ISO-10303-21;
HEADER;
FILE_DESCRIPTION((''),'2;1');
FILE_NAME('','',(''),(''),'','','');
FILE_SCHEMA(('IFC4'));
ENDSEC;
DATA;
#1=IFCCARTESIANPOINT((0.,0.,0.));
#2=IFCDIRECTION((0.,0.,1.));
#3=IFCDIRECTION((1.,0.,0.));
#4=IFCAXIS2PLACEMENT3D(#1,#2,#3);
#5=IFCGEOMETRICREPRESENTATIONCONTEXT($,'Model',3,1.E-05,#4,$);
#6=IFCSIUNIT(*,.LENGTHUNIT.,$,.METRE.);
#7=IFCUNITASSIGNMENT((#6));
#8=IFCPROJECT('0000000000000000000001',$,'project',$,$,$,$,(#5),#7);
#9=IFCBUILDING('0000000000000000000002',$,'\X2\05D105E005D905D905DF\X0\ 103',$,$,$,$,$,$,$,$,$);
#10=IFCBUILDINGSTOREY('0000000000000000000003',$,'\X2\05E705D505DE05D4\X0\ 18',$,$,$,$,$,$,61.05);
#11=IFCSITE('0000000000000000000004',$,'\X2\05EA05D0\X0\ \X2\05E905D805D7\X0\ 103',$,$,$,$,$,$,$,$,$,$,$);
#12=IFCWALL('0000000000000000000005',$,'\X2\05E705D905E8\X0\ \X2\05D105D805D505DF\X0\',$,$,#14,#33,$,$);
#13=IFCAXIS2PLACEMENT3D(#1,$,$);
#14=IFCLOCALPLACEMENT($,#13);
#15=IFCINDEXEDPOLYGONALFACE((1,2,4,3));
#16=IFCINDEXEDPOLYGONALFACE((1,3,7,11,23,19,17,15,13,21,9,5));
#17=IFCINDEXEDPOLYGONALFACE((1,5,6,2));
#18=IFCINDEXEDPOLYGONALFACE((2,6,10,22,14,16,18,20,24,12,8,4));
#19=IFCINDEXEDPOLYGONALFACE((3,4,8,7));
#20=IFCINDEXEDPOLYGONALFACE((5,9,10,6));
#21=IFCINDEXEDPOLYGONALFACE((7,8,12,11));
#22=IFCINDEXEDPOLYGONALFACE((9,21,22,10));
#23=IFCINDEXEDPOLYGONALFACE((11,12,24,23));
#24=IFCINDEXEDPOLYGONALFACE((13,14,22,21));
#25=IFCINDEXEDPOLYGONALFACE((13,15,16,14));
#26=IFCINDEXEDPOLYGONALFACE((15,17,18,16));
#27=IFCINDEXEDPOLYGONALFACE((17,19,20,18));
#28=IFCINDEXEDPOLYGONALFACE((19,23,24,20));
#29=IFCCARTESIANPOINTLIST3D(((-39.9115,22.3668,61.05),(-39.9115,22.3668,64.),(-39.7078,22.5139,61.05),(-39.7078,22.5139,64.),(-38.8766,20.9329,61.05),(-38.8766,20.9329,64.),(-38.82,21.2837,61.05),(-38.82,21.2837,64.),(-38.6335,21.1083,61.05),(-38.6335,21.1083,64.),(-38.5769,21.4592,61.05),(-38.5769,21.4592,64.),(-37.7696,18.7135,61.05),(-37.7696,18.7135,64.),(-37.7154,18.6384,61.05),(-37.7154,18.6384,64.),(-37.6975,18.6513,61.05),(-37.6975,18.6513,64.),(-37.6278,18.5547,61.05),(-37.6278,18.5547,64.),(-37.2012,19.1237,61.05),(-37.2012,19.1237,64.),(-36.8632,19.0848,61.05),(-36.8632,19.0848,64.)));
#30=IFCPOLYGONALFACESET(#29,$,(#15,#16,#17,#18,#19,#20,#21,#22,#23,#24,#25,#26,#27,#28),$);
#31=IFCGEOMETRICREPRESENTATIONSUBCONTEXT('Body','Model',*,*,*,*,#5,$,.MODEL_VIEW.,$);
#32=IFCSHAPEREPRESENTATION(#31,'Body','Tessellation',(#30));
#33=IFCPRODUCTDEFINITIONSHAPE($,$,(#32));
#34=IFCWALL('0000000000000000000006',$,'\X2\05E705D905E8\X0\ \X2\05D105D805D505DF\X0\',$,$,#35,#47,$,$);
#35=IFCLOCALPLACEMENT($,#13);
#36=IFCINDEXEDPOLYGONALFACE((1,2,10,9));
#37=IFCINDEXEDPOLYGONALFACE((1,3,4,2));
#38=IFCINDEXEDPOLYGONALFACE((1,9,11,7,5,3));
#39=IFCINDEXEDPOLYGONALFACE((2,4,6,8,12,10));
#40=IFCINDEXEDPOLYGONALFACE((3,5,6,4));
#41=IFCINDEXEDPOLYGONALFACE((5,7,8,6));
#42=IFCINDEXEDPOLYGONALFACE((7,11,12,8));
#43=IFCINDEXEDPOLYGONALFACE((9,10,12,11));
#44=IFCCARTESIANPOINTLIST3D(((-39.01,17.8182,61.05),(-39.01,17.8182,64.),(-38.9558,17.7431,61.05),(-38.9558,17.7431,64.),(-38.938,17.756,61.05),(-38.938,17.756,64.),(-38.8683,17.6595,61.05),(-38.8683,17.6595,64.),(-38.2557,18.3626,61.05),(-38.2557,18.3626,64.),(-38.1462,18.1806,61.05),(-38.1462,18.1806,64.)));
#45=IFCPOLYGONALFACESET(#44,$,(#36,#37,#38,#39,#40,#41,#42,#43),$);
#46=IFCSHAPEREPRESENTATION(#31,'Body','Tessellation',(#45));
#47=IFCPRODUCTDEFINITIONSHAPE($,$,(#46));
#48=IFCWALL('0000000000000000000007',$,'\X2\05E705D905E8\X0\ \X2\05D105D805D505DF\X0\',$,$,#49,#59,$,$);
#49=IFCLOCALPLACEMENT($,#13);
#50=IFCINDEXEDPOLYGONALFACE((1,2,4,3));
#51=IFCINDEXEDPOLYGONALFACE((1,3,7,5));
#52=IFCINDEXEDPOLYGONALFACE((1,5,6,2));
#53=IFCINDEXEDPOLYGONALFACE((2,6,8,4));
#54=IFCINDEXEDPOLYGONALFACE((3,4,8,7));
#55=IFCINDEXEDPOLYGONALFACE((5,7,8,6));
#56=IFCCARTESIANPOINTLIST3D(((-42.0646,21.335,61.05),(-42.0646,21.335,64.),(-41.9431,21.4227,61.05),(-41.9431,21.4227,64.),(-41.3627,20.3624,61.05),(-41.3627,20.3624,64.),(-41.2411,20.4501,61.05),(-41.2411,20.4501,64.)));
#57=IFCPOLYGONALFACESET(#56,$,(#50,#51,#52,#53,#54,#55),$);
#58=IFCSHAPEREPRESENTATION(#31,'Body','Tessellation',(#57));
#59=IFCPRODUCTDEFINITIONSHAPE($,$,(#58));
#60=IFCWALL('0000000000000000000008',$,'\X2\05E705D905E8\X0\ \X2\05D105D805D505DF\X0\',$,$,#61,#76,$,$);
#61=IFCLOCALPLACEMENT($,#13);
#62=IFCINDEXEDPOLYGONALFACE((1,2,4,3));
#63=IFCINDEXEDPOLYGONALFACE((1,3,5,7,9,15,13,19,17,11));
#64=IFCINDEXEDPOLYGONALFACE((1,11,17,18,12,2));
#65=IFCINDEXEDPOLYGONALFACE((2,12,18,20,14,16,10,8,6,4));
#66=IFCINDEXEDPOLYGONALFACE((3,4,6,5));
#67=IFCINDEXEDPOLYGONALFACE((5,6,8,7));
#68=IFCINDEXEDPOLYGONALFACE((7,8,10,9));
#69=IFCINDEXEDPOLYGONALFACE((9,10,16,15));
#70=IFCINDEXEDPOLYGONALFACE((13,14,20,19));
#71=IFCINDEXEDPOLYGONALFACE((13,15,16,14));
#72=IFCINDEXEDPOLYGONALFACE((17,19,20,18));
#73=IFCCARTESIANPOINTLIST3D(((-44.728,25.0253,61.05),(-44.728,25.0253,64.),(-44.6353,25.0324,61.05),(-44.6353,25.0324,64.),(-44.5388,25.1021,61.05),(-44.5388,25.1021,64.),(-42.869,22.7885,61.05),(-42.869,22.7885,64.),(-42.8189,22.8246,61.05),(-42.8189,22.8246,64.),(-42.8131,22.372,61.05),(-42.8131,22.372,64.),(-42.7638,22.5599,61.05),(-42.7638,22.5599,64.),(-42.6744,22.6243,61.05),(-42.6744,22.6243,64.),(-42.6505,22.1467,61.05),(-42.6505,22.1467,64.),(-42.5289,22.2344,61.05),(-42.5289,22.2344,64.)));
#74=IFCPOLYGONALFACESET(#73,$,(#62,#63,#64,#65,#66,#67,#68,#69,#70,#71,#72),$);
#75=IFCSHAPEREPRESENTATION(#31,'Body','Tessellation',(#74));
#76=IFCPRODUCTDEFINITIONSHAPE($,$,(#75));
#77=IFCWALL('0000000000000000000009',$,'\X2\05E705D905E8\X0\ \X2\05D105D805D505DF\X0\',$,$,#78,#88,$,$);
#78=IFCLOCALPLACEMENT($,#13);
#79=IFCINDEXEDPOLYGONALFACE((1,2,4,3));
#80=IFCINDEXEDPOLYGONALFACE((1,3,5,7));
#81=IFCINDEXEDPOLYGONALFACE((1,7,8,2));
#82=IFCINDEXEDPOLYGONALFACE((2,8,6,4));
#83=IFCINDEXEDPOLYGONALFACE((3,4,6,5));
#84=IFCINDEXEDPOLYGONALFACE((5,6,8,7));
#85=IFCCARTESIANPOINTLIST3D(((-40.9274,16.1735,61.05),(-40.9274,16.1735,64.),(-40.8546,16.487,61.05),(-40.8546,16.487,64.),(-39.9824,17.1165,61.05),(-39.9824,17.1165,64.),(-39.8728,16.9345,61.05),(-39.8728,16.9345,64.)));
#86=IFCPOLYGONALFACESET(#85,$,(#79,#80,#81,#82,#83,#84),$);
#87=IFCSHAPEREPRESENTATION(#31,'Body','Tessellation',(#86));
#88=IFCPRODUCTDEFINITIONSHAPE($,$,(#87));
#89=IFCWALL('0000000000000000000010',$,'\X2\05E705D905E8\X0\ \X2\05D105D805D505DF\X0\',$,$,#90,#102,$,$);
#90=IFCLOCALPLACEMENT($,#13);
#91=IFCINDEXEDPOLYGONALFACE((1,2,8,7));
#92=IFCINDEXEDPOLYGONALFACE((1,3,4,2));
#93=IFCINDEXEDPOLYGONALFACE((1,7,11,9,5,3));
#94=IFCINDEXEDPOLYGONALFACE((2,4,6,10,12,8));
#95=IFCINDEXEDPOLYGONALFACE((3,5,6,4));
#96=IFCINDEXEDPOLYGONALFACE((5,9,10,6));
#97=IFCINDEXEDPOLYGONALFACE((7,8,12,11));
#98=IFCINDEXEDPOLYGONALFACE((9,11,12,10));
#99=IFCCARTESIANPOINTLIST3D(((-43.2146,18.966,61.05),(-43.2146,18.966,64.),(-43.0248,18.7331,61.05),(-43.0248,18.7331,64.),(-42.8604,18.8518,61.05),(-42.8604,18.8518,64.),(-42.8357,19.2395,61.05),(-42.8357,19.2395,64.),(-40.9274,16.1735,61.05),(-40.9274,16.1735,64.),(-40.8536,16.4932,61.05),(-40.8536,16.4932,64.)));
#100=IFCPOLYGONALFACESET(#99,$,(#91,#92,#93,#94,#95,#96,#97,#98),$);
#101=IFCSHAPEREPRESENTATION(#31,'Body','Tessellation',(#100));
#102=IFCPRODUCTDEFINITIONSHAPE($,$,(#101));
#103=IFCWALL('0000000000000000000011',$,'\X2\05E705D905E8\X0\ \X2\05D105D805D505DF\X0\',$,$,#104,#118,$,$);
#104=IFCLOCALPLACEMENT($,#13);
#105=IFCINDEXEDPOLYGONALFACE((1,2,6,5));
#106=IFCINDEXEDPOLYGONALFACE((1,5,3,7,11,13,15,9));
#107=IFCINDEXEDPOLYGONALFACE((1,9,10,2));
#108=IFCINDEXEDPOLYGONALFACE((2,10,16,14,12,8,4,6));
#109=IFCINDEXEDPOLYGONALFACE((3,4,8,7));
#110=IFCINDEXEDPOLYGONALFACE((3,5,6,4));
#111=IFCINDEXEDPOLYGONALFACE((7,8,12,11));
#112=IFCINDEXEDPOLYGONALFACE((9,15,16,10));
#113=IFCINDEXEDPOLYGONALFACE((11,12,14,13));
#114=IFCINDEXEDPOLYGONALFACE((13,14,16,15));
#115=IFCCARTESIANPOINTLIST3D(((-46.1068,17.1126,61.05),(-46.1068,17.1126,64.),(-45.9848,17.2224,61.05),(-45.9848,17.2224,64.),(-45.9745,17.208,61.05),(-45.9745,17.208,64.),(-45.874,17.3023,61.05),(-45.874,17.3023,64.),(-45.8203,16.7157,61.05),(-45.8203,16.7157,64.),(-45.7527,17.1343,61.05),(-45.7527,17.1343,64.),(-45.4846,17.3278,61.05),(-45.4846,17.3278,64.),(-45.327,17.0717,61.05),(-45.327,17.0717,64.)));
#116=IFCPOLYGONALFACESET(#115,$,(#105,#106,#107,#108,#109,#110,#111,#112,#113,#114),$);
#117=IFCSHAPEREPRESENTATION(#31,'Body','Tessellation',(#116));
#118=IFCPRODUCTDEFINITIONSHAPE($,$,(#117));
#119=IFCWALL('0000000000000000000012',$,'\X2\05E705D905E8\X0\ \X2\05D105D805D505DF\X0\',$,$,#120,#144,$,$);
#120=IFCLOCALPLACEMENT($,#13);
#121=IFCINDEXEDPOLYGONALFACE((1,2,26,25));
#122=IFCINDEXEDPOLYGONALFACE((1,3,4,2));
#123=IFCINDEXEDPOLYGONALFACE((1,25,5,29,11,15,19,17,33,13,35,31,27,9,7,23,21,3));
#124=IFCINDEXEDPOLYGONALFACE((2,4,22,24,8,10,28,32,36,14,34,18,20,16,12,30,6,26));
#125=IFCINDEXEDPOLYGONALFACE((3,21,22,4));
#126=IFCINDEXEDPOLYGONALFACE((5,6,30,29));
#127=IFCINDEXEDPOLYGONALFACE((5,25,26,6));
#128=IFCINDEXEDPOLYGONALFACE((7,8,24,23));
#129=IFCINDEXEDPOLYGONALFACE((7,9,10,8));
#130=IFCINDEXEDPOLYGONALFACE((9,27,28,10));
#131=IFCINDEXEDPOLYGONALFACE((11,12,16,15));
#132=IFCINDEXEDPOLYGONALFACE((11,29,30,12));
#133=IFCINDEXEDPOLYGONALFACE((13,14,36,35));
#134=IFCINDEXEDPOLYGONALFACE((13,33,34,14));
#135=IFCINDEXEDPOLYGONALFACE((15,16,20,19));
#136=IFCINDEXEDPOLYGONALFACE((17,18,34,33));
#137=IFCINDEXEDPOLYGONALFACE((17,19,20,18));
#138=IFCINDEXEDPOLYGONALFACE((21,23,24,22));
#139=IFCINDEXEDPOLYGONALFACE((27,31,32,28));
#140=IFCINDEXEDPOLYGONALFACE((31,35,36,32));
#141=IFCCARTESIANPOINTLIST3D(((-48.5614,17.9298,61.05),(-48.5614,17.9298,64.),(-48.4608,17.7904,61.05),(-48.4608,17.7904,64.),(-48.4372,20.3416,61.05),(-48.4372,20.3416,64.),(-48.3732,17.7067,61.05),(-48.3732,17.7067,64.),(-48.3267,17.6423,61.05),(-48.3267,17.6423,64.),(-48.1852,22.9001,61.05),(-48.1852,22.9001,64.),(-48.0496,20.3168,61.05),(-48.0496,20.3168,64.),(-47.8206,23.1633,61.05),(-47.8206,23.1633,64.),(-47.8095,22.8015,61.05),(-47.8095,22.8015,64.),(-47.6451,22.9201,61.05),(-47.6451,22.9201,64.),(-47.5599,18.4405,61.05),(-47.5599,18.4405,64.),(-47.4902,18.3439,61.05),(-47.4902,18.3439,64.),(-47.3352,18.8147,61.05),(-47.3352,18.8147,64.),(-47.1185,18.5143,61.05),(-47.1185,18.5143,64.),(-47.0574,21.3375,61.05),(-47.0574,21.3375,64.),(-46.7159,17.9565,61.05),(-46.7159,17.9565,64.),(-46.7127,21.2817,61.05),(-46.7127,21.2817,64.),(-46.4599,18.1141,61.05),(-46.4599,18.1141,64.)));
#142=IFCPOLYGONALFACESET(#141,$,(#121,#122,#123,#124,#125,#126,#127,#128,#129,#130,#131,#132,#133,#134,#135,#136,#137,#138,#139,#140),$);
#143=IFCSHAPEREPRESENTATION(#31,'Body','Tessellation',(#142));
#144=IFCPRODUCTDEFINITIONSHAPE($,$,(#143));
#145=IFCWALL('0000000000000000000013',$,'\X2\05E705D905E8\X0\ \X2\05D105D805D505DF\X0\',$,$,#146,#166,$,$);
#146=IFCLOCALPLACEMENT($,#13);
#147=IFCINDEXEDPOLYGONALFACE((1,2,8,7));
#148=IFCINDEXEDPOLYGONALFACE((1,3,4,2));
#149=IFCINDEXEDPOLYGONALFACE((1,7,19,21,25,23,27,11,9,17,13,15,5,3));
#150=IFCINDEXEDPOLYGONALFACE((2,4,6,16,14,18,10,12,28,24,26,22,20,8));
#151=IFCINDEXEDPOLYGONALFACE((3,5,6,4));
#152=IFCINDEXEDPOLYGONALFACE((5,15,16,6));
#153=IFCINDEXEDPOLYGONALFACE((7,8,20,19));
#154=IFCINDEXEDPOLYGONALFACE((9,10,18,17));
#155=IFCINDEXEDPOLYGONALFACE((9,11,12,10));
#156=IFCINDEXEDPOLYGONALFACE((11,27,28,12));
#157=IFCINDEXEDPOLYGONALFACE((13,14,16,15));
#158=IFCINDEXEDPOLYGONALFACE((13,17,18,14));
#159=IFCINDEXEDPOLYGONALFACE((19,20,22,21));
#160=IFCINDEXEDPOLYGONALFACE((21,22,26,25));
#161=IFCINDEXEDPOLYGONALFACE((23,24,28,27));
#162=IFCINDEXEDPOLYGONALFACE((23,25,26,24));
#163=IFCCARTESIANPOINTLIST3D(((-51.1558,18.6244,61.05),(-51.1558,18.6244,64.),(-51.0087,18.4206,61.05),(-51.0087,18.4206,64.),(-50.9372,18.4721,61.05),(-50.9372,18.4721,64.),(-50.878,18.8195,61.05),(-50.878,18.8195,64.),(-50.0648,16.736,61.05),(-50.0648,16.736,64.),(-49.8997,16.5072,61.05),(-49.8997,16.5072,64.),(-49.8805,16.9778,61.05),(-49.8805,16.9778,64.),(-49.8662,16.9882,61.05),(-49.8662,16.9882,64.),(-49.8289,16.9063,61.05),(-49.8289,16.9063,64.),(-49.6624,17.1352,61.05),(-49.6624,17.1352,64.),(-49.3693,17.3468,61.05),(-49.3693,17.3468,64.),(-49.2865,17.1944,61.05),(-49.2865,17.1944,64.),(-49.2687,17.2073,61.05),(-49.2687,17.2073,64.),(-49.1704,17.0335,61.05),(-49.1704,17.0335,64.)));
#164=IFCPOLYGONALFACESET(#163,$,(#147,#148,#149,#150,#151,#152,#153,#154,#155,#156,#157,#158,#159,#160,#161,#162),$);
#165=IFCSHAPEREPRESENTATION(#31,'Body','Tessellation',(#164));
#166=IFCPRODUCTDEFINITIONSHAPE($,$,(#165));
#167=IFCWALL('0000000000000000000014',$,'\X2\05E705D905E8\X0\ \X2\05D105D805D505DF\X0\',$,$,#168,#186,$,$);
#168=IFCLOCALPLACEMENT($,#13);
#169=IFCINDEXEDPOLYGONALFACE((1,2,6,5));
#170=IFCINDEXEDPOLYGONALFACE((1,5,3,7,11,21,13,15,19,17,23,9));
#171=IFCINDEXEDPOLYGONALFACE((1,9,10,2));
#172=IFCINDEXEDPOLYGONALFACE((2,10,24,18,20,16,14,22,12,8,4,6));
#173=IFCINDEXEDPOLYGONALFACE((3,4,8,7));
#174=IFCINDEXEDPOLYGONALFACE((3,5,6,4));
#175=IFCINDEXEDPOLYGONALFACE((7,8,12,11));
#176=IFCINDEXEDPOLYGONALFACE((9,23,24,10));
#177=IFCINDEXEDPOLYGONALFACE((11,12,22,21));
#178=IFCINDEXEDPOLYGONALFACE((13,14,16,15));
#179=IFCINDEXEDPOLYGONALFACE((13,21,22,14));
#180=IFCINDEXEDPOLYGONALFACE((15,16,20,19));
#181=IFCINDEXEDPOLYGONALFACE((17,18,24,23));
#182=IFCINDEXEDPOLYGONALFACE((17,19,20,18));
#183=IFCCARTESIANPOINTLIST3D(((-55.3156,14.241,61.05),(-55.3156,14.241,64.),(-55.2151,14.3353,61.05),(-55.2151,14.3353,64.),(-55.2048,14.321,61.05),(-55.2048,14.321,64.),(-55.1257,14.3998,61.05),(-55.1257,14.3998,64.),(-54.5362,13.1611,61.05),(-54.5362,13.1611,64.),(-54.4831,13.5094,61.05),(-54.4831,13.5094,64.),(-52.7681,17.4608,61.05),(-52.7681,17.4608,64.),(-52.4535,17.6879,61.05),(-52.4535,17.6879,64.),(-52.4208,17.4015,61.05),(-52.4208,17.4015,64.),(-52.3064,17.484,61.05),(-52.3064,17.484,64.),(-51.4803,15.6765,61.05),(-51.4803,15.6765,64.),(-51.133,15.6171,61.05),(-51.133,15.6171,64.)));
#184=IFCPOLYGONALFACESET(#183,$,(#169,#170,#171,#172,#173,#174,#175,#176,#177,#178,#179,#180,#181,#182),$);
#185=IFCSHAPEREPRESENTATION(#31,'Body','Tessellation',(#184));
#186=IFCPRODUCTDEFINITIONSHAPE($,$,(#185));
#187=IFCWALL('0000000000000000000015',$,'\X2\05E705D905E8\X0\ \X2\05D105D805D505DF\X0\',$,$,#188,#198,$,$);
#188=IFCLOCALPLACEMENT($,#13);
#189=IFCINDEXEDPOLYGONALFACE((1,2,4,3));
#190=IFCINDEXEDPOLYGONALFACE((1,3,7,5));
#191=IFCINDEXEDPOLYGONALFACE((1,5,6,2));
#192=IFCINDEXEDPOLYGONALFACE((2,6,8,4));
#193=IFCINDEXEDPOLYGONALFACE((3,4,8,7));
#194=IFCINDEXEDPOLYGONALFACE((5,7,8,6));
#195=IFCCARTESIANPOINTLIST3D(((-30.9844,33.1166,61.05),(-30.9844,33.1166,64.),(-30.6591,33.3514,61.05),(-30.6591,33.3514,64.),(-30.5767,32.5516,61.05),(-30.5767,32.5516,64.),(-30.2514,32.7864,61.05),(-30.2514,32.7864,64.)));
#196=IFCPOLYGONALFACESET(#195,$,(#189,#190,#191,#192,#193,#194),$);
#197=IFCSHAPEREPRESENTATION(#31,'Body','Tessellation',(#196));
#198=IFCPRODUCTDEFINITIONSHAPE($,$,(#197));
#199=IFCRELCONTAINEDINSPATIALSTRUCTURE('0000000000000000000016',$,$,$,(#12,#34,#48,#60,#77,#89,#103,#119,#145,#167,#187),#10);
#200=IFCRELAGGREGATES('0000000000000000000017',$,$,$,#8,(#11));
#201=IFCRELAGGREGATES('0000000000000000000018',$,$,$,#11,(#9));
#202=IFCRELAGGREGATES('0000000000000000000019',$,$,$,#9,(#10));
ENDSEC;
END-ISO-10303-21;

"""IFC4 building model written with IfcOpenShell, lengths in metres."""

from ifc_helpers import new_model, si_unit, frame, origin_with_axes, context, subcontext, project, spatial, polyline, outline, extrude, element, save


model = new_model("IFC4")

# Units and contexts
model_context = context("Model", 3, precision=1e-05, world=origin_with_axes())
body_context = subcontext(model_context, "Body", "Model", "MODEL_VIEW")
ifc_project = project(units=[si_unit("LENGTHUNIT", "METRE")], contexts=[model_context])

# Site, building, storey
site = spatial("IfcSite", under=ifc_project, Name="תא שטח 103")
building = spatial("IfcBuilding", under=site, Name="בניין 103")
storey = spatial("IfcBuildingStorey", under=building, Name="קומה 18", Elevation=61.05)

# Walls
element("IfcWall", 1, inside=storey, Name="קיר בטון", context=body_context, shape_type="SweptSolid", body=[
    extrude(outline(polyline([(-37.6975, 18.6513), (-37.7154, 18.6384), (-37.7696, 18.7135), (-37.2012, 19.1237), (-38.6335, 21.1083), (-38.8766, 20.9329), (-39.9115, 22.3668), (-39.7078, 22.5139), (-38.82, 21.2837), (-38.5769, 21.4592), (-36.8632, 19.0848), (-37.6278, 18.5547), (-37.6975, 18.6513)])), frame((0.0, 0.0, 61.05)), (0.0, 0.0, 1.0), 2.95),
])
element("IfcWall", 2, inside=storey, Name="קיר בטון", context=body_context, shape_type="SweptSolid", body=[
    extrude(outline(polyline([(-38.938, 17.756), (-38.9558, 17.7431), (-39.01, 17.8182), (-38.2557, 18.3626), (-38.1462, 18.1806), (-38.8683, 17.6595), (-38.938, 17.756)])), frame((0.0, 0.0, 61.05)), (0.0, 0.0, 1.0), 2.95),
])
element("IfcWall", 3, inside=storey, Name="קיר בטון", context=body_context, shape_type="SweptSolid", body=[
    extrude(outline(polyline([(-41.2411, 20.4501), (-41.3627, 20.3624), (-42.0646, 21.335), (-41.9431, 21.4227), (-41.2411, 20.4501)])), frame((0.0, 0.0, 61.05)), (0.0, 0.0, 1.0), 2.95),
])
element("IfcWall", 4, inside=storey, Name="קיר בטון", context=body_context, shape_type="SweptSolid", body=[
    extrude(outline(polyline([(-42.6505, 22.1467), (-42.8131, 22.372), (-44.728, 25.0253), (-44.6353, 25.0324), (-44.5388, 25.1021), (-42.869, 22.7885), (-42.8189, 22.8246), (-42.6744, 22.6243), (-42.7638, 22.5599), (-42.5289, 22.2344), (-42.6505, 22.1467)])), frame((0.0, 0.0, 61.05)), (0.0, 0.0, 1.0), 2.95),
])
element("IfcWall", 5, inside=storey, Name="קיר בטון", context=body_context, shape_type="SweptSolid", body=[
    extrude(outline(polyline([(-40.9274, 16.1735), (-40.8546, 16.487), (-39.9824, 17.1165), (-39.8728, 16.9345), (-40.9274, 16.1735)])), frame((0.0, 0.0, 61.05)), (0.0, 0.0, 1.0), 2.95),
])
element("IfcWall", 6, inside=storey, Name="קיר בטון", context=body_context, shape_type="SweptSolid", body=[
    extrude(outline(polyline([(-43.0248, 18.7331), (-43.2146, 18.966), (-42.8357, 19.2395), (-40.8536, 16.4932), (-40.9274, 16.1735), (-42.8604, 18.8518), (-43.0248, 18.7331)])), frame((0.0, 0.0, 61.05)), (0.0, 0.0, 1.0), 2.95),
])
element("IfcWall", 7, inside=storey, Name="קיר בטון", context=body_context, shape_type="SweptSolid", body=[
    extrude(outline(polyline([(-45.9745, 17.208), (-45.9848, 17.2224), (-45.874, 17.3023), (-45.7527, 17.1343), (-45.4846, 17.3278), (-45.327, 17.0717), (-45.8203, 16.7157), (-46.1068, 17.1126), (-45.9745, 17.208)])), frame((0.0, 0.0, 61.05)), (0.0, 0.0, 1.0), 2.95),
])
element("IfcWall", 8, inside=storey, Name="קיר בטון", context=body_context, shape_type="SweptSolid", body=[
    extrude(outline(polyline([(-48.4608, 17.7904), (-48.5614, 17.9298), (-47.3352, 18.8147), (-48.4372, 20.3416), (-47.0574, 21.3375), (-48.1852, 22.9001), (-47.8206, 23.1633), (-47.6451, 22.9201), (-47.8095, 22.8015), (-46.7127, 21.2817), (-48.0496, 20.3168), (-46.4599, 18.1141), (-46.7159, 17.9565), (-47.1185, 18.5143), (-48.3267, 17.6423), (-48.3732, 17.7067), (-47.4902, 18.3439), (-47.5599, 18.4405), (-48.4608, 17.7904)])), frame((0.0, 0.0, 61.05)), (0.0, 0.0, 1.0), 2.95),
])
element("IfcWall", 9, inside=storey, Name="קיר בטון", context=body_context, shape_type="SweptSolid", body=[
    extrude(outline(polyline([(-49.2865, 17.1944), (-49.1704, 17.0335), (-49.8997, 16.5072), (-50.0648, 16.736), (-49.8289, 16.9063), (-49.8805, 16.9778), (-49.8662, 16.9882), (-50.9372, 18.4721), (-51.0087, 18.4206), (-51.1558, 18.6244), (-50.878, 18.8195), (-49.6624, 17.1352), (-49.3693, 17.3468), (-49.2687, 17.2073), (-49.2865, 17.1944)])), frame((0.0, 0.0, 61.05)), (0.0, 0.0, 1.0), 2.95),
])
element("IfcWall", 10, inside=storey, Name="קיר בטון", context=body_context, shape_type="SweptSolid", body=[
    extrude(outline(polyline([(-54.5362, 13.1611), (-55.3156, 14.241), (-55.2048, 14.321), (-55.2151, 14.3353), (-55.1257, 14.3998), (-54.4831, 13.5094), (-51.4803, 15.6765), (-52.7681, 17.4608), (-52.4535, 17.6879), (-52.3064, 17.484), (-52.4208, 17.4015), (-51.133, 15.6171), (-54.5362, 13.1611)])), frame((0.0, 0.0, 61.05)), (0.0, 0.0, 1.0), 2.95),
])
element("IfcWall", 11, inside=storey, Name="קיר בטון", context=body_context, shape_type="SweptSolid", body=[
    extrude(outline(polyline([(-30.9844, 33.1166), (-30.6591, 33.3514), (-30.2514, 32.7864), (-30.5767, 32.5516), (-30.9844, 33.1166)])), frame((0.0, 0.0, 61.05)), (0.0, 0.0, 1.0), 2.95),
])

save(model, "model.ifc")
